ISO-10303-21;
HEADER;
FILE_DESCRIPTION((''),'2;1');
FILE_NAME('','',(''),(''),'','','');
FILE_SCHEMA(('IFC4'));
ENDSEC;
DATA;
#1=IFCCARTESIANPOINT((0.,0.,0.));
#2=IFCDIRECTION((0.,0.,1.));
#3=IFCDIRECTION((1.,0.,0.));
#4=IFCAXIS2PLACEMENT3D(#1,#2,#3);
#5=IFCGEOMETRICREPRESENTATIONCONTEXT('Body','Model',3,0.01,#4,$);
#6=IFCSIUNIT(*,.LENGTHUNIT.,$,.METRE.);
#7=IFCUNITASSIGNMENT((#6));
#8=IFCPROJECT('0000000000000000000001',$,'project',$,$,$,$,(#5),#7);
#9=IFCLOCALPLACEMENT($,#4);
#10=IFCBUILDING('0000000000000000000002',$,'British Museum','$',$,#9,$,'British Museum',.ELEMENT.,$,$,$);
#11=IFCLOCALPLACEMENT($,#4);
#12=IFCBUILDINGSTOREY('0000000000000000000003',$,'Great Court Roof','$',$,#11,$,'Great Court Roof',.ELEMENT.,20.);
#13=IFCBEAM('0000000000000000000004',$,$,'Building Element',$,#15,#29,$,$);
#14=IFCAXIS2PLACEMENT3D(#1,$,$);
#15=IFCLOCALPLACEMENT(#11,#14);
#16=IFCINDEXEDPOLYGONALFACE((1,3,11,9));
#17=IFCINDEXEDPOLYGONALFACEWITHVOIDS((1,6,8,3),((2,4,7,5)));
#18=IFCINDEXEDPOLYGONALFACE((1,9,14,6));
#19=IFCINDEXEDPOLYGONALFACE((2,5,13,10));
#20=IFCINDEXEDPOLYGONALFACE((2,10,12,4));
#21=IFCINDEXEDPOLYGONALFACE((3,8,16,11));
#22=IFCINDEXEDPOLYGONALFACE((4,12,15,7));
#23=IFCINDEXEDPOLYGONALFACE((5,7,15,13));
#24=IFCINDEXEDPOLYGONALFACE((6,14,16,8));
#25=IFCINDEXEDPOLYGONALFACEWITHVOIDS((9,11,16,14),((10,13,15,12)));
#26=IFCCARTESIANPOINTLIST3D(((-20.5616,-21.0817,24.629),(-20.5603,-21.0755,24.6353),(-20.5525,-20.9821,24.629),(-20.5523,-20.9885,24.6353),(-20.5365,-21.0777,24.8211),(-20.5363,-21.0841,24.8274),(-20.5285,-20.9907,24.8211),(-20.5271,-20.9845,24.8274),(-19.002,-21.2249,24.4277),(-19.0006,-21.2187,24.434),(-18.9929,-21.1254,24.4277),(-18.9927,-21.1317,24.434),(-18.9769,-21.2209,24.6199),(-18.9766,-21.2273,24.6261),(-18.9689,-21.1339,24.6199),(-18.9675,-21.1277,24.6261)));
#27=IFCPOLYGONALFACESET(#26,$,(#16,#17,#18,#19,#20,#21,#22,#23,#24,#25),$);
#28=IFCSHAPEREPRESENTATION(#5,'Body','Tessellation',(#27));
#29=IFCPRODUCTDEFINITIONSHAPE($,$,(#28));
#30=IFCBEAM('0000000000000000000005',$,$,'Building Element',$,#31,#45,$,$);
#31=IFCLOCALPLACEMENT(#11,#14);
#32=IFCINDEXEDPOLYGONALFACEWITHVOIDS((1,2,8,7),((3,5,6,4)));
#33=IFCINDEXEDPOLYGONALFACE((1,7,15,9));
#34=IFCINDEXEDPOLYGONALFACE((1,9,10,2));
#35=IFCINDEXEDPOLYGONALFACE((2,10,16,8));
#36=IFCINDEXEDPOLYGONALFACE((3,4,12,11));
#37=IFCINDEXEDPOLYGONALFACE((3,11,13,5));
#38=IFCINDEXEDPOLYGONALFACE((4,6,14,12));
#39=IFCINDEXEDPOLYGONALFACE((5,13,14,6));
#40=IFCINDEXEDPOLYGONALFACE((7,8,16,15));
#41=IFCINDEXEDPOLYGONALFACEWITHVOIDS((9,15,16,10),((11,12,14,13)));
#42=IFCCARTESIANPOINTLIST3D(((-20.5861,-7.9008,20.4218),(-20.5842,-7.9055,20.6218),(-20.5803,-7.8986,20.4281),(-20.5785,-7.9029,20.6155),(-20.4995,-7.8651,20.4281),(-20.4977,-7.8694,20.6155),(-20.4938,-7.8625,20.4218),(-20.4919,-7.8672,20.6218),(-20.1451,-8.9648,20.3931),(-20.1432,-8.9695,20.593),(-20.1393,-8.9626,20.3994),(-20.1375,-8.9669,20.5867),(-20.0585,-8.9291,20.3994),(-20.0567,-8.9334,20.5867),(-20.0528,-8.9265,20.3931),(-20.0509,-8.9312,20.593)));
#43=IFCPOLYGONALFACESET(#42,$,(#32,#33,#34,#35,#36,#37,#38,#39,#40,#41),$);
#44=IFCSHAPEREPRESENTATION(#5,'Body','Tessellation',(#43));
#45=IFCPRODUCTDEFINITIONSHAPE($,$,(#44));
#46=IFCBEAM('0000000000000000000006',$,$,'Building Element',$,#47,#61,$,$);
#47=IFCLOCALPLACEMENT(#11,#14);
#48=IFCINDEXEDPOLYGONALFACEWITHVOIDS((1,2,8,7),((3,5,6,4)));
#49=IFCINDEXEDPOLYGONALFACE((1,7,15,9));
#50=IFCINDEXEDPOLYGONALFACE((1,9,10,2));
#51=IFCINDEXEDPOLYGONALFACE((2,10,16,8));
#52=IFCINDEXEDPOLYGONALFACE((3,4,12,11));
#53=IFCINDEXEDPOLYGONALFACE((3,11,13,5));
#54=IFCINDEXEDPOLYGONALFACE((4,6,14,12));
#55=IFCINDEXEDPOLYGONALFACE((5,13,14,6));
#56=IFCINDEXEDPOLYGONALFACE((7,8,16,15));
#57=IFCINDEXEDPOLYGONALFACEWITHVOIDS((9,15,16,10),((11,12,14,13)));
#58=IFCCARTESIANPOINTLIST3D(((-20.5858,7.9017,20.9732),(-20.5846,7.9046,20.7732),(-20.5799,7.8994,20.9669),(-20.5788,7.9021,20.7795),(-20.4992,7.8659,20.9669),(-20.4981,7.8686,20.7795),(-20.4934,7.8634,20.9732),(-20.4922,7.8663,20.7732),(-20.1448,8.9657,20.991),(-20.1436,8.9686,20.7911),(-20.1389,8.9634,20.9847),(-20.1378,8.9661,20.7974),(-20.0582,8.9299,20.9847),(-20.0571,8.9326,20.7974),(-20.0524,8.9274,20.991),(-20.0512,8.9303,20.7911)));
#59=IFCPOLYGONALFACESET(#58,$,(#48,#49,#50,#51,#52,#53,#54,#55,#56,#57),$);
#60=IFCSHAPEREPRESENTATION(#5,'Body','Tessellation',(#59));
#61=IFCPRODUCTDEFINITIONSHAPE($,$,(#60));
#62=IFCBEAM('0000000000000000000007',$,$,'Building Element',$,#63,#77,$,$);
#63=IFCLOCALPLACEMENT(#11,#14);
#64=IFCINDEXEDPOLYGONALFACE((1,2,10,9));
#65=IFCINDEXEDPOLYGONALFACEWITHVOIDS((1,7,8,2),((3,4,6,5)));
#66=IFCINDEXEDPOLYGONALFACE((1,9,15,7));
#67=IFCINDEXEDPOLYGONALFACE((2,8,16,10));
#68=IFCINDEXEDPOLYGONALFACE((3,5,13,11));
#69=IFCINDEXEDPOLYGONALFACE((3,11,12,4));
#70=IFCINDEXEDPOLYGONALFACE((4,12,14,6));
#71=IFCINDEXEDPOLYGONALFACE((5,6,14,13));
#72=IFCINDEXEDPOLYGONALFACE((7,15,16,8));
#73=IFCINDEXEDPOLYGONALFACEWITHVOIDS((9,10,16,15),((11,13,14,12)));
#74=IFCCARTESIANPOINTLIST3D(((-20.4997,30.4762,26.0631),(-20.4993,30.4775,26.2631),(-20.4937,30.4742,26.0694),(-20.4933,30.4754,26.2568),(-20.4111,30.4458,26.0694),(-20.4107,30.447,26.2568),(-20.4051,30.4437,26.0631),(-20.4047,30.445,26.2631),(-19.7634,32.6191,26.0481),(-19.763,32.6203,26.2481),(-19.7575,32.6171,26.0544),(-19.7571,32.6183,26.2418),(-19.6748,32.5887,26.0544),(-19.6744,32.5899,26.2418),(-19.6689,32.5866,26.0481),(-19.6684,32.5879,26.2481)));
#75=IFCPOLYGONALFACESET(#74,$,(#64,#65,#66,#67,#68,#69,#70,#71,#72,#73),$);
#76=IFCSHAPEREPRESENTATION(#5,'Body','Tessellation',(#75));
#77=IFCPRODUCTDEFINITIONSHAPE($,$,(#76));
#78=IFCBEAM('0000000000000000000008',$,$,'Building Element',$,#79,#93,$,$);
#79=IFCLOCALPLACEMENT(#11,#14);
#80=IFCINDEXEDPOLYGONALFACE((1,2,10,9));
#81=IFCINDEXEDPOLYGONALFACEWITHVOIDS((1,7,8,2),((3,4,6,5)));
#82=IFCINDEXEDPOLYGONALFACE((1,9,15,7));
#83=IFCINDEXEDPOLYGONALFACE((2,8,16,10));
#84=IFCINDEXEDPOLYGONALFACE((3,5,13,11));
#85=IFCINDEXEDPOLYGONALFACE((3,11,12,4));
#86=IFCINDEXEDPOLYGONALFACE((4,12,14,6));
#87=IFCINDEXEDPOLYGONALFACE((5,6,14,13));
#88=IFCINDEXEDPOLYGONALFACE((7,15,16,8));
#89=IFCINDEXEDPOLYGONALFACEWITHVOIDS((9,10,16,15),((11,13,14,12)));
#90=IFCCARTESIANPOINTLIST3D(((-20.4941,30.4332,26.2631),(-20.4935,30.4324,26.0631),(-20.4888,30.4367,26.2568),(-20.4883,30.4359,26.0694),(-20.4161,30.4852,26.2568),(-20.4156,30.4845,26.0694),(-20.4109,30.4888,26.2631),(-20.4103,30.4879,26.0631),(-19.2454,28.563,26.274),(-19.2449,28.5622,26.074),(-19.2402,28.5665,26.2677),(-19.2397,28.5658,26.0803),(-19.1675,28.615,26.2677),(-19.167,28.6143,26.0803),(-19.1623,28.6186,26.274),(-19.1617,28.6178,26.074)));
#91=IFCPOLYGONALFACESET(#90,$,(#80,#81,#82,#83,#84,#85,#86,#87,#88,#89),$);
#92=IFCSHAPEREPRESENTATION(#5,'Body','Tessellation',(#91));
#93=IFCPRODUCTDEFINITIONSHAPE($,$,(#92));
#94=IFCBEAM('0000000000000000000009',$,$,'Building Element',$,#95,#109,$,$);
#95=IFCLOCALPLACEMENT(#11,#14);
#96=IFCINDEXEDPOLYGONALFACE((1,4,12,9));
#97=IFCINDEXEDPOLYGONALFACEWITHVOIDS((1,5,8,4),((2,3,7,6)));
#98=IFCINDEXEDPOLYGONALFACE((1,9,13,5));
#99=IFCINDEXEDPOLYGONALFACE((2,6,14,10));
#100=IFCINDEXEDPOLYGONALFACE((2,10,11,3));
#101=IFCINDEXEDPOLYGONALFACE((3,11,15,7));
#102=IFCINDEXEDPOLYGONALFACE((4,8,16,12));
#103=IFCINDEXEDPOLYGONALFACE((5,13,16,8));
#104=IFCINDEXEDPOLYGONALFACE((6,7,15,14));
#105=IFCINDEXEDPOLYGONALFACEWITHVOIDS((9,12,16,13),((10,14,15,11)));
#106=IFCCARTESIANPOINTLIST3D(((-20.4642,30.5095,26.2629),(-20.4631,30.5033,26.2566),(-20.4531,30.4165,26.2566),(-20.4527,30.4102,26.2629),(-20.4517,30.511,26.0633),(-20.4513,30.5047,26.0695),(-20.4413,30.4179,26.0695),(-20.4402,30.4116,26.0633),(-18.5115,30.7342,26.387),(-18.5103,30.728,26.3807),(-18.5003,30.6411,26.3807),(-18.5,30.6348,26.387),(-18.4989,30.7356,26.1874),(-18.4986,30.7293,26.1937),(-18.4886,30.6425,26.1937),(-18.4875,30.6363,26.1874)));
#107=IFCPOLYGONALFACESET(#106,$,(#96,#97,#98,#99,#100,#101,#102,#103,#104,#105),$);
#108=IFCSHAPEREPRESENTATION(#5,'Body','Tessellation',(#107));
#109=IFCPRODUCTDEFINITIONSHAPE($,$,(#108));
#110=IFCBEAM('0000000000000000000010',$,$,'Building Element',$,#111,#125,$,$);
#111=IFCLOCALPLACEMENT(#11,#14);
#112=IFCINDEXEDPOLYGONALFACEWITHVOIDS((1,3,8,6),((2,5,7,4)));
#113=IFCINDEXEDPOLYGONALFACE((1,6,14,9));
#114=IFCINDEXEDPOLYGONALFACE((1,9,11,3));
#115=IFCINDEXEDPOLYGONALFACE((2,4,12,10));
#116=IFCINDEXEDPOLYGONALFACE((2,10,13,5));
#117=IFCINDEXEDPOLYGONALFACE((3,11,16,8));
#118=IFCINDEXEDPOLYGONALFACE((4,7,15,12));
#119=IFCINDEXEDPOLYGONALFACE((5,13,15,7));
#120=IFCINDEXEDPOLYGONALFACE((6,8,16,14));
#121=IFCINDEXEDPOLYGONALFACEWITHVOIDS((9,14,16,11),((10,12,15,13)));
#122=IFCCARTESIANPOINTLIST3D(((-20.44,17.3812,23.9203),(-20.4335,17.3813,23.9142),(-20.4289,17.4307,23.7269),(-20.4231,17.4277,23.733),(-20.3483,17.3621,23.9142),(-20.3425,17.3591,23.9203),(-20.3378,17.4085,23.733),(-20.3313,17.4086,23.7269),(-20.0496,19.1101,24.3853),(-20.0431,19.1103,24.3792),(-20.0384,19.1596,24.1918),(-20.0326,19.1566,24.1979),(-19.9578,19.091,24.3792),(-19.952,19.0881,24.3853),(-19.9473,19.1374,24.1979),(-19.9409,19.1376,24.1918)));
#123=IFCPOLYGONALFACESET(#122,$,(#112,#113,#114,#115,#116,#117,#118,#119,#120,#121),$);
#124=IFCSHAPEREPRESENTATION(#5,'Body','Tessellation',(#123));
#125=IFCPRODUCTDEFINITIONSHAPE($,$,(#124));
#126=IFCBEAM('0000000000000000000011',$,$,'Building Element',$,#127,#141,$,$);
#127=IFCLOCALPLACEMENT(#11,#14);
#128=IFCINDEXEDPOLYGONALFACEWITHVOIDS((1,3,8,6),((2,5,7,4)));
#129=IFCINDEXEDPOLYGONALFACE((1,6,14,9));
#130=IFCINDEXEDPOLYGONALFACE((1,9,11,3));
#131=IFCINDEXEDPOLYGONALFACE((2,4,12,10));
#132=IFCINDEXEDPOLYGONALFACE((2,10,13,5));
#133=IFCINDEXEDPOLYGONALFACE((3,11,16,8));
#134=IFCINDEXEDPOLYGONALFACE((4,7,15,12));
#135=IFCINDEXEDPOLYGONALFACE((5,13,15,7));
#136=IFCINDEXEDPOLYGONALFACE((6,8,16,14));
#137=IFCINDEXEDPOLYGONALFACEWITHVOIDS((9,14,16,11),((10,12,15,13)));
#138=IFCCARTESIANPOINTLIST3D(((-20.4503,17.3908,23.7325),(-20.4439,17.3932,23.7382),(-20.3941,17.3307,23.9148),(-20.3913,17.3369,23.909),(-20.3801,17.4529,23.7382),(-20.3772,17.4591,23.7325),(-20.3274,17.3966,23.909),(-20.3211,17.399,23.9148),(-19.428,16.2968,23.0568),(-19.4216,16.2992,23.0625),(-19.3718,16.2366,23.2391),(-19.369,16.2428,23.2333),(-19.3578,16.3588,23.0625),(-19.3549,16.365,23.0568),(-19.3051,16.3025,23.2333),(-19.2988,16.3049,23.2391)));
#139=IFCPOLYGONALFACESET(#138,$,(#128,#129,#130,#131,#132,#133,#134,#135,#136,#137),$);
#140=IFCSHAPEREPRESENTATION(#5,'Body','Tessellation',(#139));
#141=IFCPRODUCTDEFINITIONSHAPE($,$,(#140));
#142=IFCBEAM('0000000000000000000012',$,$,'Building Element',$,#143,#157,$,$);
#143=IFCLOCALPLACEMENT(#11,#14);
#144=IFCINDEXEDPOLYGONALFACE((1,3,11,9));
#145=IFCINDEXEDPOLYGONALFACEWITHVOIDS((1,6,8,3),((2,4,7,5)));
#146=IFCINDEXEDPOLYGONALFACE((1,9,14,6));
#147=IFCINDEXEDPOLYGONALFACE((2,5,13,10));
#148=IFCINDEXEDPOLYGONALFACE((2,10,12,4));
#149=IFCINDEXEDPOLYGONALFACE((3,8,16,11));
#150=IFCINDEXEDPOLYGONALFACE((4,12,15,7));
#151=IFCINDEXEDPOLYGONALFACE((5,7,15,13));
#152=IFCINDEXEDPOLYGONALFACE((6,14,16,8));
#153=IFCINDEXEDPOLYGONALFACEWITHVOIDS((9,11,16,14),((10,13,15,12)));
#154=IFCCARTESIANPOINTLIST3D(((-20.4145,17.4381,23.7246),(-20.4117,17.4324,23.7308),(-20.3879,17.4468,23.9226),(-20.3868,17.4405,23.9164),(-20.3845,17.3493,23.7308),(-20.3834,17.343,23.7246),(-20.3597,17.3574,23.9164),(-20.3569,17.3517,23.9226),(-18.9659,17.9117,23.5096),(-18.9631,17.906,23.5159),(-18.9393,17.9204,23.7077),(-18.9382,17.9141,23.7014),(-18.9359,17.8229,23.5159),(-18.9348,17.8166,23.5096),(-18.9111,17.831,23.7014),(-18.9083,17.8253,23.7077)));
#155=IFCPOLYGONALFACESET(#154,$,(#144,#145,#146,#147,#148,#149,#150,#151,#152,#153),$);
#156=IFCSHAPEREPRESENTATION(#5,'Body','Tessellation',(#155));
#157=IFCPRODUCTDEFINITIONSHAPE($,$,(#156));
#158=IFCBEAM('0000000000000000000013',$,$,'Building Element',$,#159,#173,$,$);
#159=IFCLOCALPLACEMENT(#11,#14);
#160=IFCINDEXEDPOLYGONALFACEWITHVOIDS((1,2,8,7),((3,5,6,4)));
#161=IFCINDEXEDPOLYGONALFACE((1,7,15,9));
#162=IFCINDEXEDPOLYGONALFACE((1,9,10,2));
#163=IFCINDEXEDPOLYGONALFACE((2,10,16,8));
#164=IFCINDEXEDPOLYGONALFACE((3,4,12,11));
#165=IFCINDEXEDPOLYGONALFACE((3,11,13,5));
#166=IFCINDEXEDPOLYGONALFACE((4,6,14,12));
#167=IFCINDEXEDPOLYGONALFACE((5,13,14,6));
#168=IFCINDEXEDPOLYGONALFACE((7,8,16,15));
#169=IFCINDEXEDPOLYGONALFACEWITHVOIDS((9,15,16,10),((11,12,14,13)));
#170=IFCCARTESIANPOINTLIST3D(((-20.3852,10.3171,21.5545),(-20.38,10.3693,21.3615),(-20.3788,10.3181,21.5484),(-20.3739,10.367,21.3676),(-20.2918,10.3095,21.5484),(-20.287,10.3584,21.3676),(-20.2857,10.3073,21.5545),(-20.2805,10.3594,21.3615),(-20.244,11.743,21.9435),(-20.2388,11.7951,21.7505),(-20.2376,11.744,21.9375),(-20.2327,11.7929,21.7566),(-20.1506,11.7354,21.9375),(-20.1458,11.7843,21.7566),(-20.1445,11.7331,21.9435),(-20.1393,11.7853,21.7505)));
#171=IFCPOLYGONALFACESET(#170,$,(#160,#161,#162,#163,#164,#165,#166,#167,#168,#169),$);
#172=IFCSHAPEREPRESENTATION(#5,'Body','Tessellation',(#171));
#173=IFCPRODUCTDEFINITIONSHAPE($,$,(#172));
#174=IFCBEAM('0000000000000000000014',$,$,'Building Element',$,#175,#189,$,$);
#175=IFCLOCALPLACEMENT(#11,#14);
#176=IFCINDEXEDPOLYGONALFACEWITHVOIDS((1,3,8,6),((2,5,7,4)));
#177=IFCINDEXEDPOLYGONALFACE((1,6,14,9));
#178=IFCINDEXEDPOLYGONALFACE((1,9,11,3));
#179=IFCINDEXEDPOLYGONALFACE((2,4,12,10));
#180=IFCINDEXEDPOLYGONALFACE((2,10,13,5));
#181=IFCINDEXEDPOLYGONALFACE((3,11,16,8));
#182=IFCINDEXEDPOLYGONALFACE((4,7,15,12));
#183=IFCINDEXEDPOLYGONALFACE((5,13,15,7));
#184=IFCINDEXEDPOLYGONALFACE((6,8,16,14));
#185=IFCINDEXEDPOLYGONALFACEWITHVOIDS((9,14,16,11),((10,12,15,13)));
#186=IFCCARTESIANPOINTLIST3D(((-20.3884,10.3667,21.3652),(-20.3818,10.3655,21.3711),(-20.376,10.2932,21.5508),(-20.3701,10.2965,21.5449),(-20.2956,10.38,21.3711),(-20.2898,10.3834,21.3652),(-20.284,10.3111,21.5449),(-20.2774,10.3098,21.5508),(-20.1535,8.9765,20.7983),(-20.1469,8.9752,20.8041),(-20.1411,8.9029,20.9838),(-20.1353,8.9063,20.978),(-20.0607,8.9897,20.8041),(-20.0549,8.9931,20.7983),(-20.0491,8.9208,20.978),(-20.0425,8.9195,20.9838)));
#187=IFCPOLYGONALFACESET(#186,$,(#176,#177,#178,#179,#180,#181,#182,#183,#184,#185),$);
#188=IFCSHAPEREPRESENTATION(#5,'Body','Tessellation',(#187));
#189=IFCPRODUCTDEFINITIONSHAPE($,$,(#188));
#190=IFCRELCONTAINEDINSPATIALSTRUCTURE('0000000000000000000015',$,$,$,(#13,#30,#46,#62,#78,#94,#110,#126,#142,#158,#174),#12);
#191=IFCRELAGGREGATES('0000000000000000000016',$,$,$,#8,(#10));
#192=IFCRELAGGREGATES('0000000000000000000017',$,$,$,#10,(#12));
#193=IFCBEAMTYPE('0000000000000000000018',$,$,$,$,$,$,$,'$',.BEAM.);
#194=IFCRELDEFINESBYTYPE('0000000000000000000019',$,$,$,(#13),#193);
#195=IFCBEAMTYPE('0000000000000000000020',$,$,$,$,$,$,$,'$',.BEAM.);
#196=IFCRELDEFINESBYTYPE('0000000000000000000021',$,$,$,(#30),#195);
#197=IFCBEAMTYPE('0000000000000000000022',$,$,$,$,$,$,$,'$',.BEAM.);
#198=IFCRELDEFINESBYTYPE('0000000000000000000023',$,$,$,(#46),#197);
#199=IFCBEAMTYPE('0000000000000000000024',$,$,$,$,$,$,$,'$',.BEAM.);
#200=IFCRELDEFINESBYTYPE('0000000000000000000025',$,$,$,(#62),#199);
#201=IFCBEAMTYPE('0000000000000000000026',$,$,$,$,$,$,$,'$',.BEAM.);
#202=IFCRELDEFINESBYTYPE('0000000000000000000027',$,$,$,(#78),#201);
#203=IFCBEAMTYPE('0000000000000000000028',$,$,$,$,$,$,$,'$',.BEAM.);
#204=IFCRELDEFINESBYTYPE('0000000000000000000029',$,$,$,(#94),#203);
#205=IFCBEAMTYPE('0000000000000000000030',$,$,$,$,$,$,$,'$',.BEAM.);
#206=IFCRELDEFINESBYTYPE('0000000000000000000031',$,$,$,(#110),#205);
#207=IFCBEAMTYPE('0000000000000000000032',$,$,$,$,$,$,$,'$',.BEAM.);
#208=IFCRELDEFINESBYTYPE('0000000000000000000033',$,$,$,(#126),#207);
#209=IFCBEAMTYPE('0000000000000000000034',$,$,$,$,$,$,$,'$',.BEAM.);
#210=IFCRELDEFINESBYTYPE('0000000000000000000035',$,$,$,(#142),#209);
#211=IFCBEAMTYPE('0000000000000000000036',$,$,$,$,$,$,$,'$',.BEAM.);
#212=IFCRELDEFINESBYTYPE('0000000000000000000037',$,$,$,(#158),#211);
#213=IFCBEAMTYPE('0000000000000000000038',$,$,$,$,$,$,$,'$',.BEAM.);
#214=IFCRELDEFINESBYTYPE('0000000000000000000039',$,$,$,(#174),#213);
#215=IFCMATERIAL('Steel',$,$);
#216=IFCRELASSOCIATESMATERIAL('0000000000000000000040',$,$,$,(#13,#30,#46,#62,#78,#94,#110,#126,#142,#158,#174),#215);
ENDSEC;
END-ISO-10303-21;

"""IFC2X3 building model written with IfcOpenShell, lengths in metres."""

from ifc_helpers import new_model, si_unit, frame, origin_with_axes, origin_2d, place, context, project, spatial, hollow_rectangle, extrude, material, type_object, element, save


model = new_model("IFC2X3")

# Units and contexts
model_context = context("Model", 3, precision=0.01, world=origin_with_axes(), identifier="Body")
ifc_project = project(units=[si_unit("LENGTHUNIT", "METRE")], contexts=[model_context])

# Building, storey
building_placement = place(None, origin_with_axes())
building = spatial("IfcBuilding", under=ifc_project, at=building_placement, Name="British Museum", Description="$", LongName="British Museum", CompositionType="ELEMENT")
storey_placement = place(None, origin_with_axes())
storey = spatial("IfcBuildingStorey", under=building, at=storey_placement, Name="Great Court Roof", Description="$", LongName="Great Court Roof", CompositionType="ELEMENT", Elevation=20.0)

# Beams
ifc_material = material(Name="Steel")
beam_type_1 = type_object("IfcBeamType", ElementType="$", PredefinedType="BEAM")
beam_1_placement = place(None, origin_with_axes())
element("IfcBeam", 1, at=beam_1_placement, inside=storey, type_object=beam_type_1, material=ifc_material, Description="Building Element", context=model_context, shape_type="SweptSolid", body=[
    extrude(hollow_rectangle(XDim=0.1, YDim=0.2, WallThickness=0.0063, InnerFilletRadius=-0.0063, OuterFilletRadius=0.0, at=origin_2d()), frame((-20.5444, -21.0331, 24.7282), z_axis=(0.987688, -0.0907, -0.127462), x_axis=(0.091446, 0.99581, 0.0)), (0.0, 0.0, 1.0), 1.5791),
])
beam_type_2 = type_object("IfcBeamType", ElementType="$", PredefinedType="BEAM")
beam_2_placement = place(None, origin_with_axes())
element("IfcBeam", 2, at=beam_2_placement, inside=storey, type_object=beam_type_2, material=ifc_material, Description="Building Element", context=model_context, shape_type="SweptSolid", body=[
    extrude(hollow_rectangle(XDim=0.1, YDim=0.2, WallThickness=0.0063, InnerFilletRadius=-0.0063, OuterFilletRadius=0.0, at=origin_2d()), frame((-20.539, -7.884, 20.5218), z_axis=(0.382769, -0.923507, -0.024967), x_axis=(0.923795, 0.382889, 0.0)), (0.0, 0.0, 1.0), 1.1521),
])
beam_type_3 = type_object("IfcBeamType", ElementType="$", PredefinedType="BEAM")
beam_3_placement = place(None, origin_with_axes())
element("IfcBeam", 3, at=beam_3_placement, inside=storey, type_object=beam_type_3, material=ifc_material, Description="Building Element", context=model_context, shape_type="SweptSolid", body=[
    extrude(hollow_rectangle(XDim=0.1, YDim=0.2, WallThickness=0.0063, InnerFilletRadius=-0.0063, OuterFilletRadius=0.0, at=origin_2d()), frame((-20.539, 7.884, 20.8732), z_axis=(0.382842, 0.923683, 0.015528), x_axis=(-0.923795, 0.382889, 0.0)), (0.0, 0.0, 1.0), 1.1519),
])
beam_type_4 = type_object("IfcBeamType", ElementType="$", PredefinedType="BEAM")
beam_4_placement = place(None, origin_with_axes())
element("IfcBeam", 4, at=beam_4_placement, inside=storey, type_object=beam_type_4, material=ifc_material, Description="Building Element", context=model_context, shape_type="SweptSolid", body=[
    extrude(hollow_rectangle(XDim=0.1, YDim=0.2, WallThickness=0.0063, InnerFilletRadius=-0.0063, OuterFilletRadius=0.0, at=origin_2d()), frame((-20.4522, 30.4606, 26.1631), z_axis=(0.324939, 0.945712, -0.00659), x_axis=(-0.945733, 0.324946, 0.0)), (0.0, 0.0, 1.0), 2.2659),
])
beam_type_5 = type_object("IfcBeamType", ElementType="$", PredefinedType="BEAM")
beam_5_placement = place(None, origin_with_axes())
element("IfcBeam", 5, at=beam_5_placement, inside=storey, type_object=beam_type_5, material=ifc_material, Description="Building Element", context=model_context, shape_type="SweptSolid", body=[
    extrude(hollow_rectangle(XDim=0.1, YDim=0.2, WallThickness=0.0063, InnerFilletRadius=-0.0063, OuterFilletRadius=0.0, at=origin_2d()), frame((-20.4522, 30.4606, 26.1631), z_axis=(0.555258, -0.831664, 0.004875), x_axis=(0.831674, 0.555265, 0.0)), (0.0, 0.0, 1.0), 2.2487),
])
beam_type_6 = type_object("IfcBeamType", ElementType="$", PredefinedType="BEAM")
beam_6_placement = place(None, origin_with_axes())
element("IfcBeam", 6, at=beam_6_placement, inside=storey, type_object=beam_type_6, material=ifc_material, Description="Building Element", context=model_context, shape_type="SweptSolid", body=[
    extrude(hollow_rectangle(XDim=0.1, YDim=0.2, WallThickness=0.0063, InnerFilletRadius=-0.0063, OuterFilletRadius=0.0, at=origin_2d()), frame((-20.4522, 30.4606, 26.1631), z_axis=(0.991473, 0.114053, 0.063033), x_axis=(-0.11428, 0.993449, 0.0)), (0.0, 0.0, 1.0), 1.9695),
])
beam_type_7 = type_object("IfcBeamType", ElementType="$", PredefinedType="BEAM")
beam_7_placement = place(None, origin_with_axes())
element("IfcBeam", 7, at=beam_7_placement, inside=storey, type_object=beam_type_7, material=ifc_material, Description="Building Element", context=model_context, shape_type="SweptSolid", body=[
    extrude(hollow_rectangle(XDim=0.1, YDim=0.2, WallThickness=0.0063, InnerFilletRadius=-0.0063, OuterFilletRadius=0.0, at=origin_2d()), frame((-20.3857, 17.3949, 23.8236), z_axis=(0.213082, 0.943509, 0.253745), x_axis=(-0.975434, 0.220292, 0.0)), (0.0, 0.0, 1.0), 1.8324),
])
beam_type_8 = type_object("IfcBeamType", ElementType="$", PredefinedType="BEAM")
beam_8_placement = place(None, origin_with_axes())
element("IfcBeam", 8, at=beam_8_placement, inside=storey, type_object=beam_type_8, material=ifc_material, Description="Building Element", context=model_context, shape_type="SweptSolid", body=[
    extrude(hollow_rectangle(XDim=0.1, YDim=0.2, WallThickness=0.0063, InnerFilletRadius=-0.0063, OuterFilletRadius=0.0, at=origin_2d()), frame((-20.3857, 17.3949, 23.8236), z_axis=(0.622305, -0.666001, -0.411314), x_axis=(0.73067, 0.682731, 0.0)), (0.0, 0.0, 1.0), 1.6427),
])
beam_type_9 = type_object("IfcBeamType", ElementType="$", PredefinedType="BEAM")
beam_9_placement = place(None, origin_with_axes())
element("IfcBeam", 9, at=beam_9_placement, inside=storey, type_object=beam_type_9, material=ifc_material, Description="Building Element", context=model_context, shape_type="SweptSolid", body=[
    extrude(hollow_rectangle(XDim=0.1, YDim=0.2, WallThickness=0.0063, InnerFilletRadius=-0.0063, OuterFilletRadius=0.0, at=origin_2d()), frame((-20.3857, 17.3949, 23.8236), z_axis=(0.941179, 0.307694, -0.139662), x_axis=(-0.31074, 0.950495, 0.0)), (0.0, 0.0, 1.0), 1.5391),
])
beam_type_10 = type_object("IfcBeamType", ElementType="$", PredefinedType="BEAM")
beam_10_placement = place(None, origin_with_axes())
element("IfcBeam", 10, at=beam_10_placement, inside=storey, type_object=beam_type_10, material=ifc_material, Description="Building Element", context=model_context, shape_type="SweptSolid", body=[
    extrude(hollow_rectangle(XDim=0.1, YDim=0.2, WallThickness=0.0063, InnerFilletRadius=-0.0063, OuterFilletRadius=0.0, at=origin_2d()), frame((-20.3329, 10.3383, 21.458), z_axis=(0.095104, 0.96036, 0.262039), x_axis=(-0.995132, 0.098547, 0.0)), (0.0, 0.0, 1.0), 1.4847),
])
beam_type_11 = type_object("IfcBeamType", ElementType="$", PredefinedType="BEAM")
beam_11_placement = place(None, origin_with_axes())
element("IfcBeam", 11, at=beam_11_placement, inside=storey, type_object=beam_type_11, material=ifc_material, Description="Building Element", context=model_context, shape_type="SweptSolid", body=[
    extrude(hollow_rectangle(XDim=0.1, YDim=0.2, WallThickness=0.0063, InnerFilletRadius=-0.0063, OuterFilletRadius=0.0, at=origin_2d()), frame((-20.3329, 10.3383, 21.458), z_axis=(0.15455, -0.914844, -0.373061), x_axis=(0.986029, 0.166576, 0.0)), (0.0, 0.0, 1.0), 1.5197),
])

save(model, "model.ifc")
